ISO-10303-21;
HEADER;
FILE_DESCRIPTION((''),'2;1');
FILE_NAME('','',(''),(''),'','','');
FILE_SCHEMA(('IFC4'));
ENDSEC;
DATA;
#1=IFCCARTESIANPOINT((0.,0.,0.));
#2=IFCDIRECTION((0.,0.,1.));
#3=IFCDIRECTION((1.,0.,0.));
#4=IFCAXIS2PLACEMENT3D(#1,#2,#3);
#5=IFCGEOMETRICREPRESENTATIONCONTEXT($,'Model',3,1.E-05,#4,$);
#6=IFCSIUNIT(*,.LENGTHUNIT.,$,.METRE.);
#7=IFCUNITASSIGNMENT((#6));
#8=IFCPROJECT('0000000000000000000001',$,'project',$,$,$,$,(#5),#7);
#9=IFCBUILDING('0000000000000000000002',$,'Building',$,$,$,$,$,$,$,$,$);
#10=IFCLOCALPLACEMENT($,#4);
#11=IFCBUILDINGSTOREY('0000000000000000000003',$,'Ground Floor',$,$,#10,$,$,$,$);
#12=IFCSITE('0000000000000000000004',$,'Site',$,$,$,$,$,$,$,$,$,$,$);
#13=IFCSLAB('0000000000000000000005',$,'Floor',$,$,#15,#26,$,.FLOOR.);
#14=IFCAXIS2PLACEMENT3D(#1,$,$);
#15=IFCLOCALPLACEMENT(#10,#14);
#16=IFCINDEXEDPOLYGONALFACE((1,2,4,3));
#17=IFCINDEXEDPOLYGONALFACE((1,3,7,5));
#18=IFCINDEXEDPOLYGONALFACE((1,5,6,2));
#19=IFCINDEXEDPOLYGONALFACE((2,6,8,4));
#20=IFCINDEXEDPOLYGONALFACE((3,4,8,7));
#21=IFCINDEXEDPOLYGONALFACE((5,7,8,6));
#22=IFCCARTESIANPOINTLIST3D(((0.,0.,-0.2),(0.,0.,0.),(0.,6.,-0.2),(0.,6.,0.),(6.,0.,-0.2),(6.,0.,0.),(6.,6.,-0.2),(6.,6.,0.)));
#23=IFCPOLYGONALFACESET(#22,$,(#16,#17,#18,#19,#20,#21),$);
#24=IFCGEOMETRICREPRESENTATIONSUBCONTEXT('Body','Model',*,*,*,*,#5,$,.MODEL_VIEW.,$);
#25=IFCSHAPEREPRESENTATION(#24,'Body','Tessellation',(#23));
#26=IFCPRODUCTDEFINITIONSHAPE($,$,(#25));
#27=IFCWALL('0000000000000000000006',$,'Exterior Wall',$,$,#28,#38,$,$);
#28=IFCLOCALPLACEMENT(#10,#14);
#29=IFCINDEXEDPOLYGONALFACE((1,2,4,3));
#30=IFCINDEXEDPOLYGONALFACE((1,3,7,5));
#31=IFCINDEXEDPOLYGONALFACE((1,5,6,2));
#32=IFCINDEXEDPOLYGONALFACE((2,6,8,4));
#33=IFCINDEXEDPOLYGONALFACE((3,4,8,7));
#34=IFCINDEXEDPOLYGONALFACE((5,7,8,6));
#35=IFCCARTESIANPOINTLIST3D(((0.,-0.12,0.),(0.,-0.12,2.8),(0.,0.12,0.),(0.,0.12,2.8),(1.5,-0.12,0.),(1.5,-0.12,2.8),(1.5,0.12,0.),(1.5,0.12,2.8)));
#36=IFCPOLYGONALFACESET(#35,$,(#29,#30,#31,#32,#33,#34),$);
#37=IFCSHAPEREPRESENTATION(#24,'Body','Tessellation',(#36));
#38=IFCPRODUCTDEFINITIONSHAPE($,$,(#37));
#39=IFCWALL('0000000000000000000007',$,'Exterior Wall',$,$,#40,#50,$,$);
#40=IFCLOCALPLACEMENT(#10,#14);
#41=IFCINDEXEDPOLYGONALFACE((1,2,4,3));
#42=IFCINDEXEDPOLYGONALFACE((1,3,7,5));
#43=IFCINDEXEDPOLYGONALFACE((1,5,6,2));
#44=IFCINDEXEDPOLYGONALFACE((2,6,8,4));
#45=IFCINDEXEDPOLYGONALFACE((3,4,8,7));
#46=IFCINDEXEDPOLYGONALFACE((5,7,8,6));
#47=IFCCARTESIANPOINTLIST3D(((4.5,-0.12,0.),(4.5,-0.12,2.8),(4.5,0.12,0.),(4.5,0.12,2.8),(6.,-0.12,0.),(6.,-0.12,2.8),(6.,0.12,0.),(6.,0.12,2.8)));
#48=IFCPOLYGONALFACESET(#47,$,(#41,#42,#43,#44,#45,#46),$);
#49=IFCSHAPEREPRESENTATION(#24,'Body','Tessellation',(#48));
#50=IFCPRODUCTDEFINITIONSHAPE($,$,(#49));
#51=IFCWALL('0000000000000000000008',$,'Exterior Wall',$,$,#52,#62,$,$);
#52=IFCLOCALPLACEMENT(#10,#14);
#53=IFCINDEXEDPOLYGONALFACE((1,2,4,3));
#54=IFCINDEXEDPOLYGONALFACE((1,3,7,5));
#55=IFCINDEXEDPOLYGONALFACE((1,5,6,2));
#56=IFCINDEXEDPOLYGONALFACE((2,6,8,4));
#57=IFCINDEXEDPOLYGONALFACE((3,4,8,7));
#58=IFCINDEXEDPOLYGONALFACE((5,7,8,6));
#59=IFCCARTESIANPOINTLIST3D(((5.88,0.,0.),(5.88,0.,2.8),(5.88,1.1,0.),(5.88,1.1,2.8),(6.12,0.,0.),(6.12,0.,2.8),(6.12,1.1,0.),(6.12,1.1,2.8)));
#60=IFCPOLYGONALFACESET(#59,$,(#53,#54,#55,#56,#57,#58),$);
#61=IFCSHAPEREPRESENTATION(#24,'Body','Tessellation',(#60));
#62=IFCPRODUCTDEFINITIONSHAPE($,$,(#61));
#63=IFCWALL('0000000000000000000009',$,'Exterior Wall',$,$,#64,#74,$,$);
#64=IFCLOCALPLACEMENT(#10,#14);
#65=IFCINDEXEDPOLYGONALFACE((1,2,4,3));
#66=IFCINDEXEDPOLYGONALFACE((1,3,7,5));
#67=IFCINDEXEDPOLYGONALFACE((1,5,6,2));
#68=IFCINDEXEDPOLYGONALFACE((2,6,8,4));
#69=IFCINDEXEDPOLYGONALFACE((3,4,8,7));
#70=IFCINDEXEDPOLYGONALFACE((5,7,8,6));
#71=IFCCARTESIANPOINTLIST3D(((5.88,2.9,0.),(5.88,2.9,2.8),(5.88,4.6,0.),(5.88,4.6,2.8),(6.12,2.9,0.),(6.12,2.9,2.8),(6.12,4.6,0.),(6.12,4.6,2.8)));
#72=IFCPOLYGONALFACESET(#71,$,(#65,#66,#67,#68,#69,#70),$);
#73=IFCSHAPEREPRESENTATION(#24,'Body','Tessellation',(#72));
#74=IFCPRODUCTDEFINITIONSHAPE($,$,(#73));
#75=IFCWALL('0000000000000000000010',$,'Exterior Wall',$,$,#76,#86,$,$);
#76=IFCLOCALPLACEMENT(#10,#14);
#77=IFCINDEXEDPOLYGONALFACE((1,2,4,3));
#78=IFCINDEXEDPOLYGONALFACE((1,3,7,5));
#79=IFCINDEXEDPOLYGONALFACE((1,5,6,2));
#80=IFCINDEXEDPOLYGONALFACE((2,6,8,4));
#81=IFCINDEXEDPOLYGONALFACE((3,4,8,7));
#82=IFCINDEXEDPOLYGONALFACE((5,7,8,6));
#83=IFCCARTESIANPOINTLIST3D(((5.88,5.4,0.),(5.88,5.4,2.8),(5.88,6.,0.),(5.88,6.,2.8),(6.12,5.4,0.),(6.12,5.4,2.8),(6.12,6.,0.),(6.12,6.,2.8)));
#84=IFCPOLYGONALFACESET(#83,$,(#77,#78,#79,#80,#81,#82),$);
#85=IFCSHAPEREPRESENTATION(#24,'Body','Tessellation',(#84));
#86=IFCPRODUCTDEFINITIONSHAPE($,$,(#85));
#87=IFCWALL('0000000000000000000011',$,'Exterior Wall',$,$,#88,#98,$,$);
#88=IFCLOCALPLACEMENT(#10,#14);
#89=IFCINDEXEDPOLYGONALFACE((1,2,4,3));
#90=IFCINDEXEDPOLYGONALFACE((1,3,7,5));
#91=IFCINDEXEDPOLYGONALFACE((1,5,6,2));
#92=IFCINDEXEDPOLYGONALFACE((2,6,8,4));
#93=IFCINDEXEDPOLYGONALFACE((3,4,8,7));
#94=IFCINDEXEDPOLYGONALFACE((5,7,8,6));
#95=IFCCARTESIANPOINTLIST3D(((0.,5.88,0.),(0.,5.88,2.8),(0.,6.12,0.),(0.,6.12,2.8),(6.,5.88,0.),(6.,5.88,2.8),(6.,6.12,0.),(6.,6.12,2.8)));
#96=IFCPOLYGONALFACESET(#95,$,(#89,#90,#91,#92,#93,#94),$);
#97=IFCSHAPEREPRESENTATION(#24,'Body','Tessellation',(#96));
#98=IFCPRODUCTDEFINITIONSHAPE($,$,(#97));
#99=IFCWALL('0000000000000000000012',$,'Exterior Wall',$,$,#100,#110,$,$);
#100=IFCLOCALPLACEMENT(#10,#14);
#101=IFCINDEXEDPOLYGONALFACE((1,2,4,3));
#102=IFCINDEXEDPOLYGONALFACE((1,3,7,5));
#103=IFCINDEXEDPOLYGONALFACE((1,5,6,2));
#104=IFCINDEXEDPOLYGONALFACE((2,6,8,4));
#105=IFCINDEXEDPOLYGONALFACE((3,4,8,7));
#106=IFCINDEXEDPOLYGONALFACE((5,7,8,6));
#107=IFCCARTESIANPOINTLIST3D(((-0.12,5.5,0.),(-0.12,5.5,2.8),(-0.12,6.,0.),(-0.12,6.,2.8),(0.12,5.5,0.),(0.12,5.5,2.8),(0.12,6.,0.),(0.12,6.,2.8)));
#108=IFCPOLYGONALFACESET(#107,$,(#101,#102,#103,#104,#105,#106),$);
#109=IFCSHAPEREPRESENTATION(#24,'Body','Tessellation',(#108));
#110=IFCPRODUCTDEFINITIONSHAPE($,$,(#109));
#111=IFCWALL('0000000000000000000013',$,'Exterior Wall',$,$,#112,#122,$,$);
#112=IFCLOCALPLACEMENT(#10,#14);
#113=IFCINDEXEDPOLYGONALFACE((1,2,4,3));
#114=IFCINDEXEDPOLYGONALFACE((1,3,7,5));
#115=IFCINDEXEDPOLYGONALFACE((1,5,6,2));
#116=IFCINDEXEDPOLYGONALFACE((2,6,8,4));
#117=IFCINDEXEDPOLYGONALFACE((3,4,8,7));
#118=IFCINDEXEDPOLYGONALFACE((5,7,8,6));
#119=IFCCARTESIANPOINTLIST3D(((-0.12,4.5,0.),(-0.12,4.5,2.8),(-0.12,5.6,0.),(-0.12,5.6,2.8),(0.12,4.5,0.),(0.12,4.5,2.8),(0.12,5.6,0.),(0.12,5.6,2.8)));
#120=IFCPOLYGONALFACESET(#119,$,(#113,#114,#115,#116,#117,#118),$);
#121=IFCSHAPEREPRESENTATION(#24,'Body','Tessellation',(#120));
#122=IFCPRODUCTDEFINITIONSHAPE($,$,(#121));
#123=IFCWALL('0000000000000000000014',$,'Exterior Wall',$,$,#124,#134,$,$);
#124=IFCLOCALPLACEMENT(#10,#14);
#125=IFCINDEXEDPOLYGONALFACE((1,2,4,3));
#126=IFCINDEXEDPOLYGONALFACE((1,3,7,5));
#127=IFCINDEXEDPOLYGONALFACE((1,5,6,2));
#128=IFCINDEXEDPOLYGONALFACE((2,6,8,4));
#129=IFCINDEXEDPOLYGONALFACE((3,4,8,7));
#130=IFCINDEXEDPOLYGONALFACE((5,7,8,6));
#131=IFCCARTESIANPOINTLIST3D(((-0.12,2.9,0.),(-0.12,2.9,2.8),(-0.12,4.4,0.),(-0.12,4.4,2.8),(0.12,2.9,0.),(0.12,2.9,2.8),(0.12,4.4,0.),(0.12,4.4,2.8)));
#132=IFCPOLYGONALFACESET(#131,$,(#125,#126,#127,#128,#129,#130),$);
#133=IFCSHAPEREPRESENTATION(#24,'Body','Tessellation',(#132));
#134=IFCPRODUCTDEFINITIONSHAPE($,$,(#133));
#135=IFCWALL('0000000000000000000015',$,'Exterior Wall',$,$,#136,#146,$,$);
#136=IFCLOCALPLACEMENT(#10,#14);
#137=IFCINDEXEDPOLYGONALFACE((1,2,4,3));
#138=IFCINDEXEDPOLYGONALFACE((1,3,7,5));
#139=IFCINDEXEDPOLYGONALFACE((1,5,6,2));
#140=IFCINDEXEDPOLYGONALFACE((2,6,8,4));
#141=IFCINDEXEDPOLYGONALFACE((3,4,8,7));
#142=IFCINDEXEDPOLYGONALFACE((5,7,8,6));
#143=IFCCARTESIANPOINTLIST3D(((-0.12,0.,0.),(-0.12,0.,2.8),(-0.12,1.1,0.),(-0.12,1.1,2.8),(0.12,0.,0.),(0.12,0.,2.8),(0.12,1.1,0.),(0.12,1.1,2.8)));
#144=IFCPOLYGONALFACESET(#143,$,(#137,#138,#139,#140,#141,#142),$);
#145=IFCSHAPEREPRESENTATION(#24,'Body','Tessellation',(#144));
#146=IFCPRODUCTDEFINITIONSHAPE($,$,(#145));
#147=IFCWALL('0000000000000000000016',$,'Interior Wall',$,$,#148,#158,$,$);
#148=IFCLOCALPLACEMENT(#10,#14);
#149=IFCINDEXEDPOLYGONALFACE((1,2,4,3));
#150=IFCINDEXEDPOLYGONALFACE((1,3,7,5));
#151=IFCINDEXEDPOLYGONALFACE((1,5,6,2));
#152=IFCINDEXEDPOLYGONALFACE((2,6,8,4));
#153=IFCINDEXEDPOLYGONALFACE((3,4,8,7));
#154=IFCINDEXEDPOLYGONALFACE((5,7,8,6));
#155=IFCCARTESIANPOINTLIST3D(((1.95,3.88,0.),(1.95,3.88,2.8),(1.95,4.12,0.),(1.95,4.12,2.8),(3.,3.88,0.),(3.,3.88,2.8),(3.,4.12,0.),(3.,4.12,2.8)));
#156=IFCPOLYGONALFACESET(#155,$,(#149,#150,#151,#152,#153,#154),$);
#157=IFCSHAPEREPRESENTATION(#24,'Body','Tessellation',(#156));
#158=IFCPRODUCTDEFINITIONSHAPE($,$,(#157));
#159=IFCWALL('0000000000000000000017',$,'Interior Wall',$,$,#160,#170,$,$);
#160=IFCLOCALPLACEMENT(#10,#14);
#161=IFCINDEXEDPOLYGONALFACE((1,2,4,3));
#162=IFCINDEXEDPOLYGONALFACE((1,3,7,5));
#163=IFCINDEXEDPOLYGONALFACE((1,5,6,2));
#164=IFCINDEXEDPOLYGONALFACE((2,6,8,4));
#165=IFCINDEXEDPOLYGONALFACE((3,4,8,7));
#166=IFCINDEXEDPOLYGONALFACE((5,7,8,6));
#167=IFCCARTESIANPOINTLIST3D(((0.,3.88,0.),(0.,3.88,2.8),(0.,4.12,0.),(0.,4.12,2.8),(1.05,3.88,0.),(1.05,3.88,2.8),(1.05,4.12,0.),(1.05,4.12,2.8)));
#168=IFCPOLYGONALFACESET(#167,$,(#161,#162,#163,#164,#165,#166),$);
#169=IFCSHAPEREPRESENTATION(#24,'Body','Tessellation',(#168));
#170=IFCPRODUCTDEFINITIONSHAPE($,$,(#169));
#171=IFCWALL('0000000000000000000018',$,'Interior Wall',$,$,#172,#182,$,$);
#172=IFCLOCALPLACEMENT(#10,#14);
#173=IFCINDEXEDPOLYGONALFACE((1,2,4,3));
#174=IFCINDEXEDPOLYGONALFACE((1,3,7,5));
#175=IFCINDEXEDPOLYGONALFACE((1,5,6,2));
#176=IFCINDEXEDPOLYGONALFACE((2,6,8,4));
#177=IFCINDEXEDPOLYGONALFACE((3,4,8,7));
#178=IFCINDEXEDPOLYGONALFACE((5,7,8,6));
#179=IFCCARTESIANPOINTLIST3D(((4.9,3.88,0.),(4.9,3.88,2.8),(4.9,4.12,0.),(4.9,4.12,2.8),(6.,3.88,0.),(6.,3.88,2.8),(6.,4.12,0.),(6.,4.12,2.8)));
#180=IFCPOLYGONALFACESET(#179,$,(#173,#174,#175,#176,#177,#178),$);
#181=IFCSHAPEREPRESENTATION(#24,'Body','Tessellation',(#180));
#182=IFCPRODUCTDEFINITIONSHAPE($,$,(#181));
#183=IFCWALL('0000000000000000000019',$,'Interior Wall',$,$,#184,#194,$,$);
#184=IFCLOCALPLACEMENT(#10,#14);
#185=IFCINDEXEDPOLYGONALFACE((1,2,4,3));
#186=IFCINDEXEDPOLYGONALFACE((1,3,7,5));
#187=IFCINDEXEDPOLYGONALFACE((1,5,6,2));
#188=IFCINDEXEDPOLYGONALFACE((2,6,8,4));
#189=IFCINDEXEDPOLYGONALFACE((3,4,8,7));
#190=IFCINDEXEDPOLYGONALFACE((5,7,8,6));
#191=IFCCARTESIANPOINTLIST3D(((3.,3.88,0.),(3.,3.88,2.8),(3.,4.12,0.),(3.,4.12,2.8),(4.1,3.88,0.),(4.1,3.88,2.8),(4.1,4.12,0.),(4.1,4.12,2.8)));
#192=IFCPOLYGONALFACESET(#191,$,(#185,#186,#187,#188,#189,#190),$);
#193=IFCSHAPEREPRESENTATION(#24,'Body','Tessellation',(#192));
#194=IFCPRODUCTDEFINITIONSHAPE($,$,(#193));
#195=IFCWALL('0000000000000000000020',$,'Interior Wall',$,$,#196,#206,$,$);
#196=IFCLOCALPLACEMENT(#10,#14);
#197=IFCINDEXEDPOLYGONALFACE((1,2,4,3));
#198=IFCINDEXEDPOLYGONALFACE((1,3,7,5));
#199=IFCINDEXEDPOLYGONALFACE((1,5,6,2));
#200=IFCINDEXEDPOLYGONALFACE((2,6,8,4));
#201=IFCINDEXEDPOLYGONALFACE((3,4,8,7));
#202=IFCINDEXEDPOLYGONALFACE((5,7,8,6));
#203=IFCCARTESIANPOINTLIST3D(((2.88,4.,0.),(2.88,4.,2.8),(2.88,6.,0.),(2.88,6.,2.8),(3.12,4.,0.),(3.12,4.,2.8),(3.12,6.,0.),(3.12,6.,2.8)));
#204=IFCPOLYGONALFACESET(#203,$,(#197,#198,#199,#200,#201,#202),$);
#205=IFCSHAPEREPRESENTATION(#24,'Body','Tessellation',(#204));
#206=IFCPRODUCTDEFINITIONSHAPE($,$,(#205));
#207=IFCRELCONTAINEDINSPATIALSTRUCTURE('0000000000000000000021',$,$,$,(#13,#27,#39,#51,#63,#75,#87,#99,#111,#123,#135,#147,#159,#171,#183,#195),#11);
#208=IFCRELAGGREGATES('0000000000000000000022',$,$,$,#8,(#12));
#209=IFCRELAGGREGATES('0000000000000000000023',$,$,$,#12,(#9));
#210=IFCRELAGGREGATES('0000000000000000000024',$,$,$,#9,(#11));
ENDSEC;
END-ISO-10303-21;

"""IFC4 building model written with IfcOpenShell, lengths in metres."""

from ifc_helpers import new_model, si_unit, frame, origin_with_axes, place, context, subcontext, project, spatial, indexed_curve, outline, extrude, element, save


model = new_model("IFC4")

# Units and contexts
model_context = context("Model", 3, precision=1e-05, world=origin_with_axes())
body_context = subcontext(model_context, "Body", "Model", "MODEL_VIEW")
ifc_project = project(units=[si_unit("LENGTHUNIT", "METRE")], contexts=[model_context])

# Site, building, storey
site = spatial("IfcSite", under=ifc_project, Name="Site")
building = spatial("IfcBuilding", under=site, Name="Building")
storey_placement = place(None, origin_with_axes())
storey = spatial("IfcBuildingStorey", under=building, at=storey_placement, Name="Ground Floor")

# Slab
slab_placement = place(storey_placement, frame((0.0, 0.0, -0.2), z_axis=(0.0, 0.0, 1.0), x_axis=(1.0, 0.0, 0.0)))
element("IfcSlab", 1, at=slab_placement, inside=storey, Name="Floor", PredefinedType="FLOOR", context=body_context, shape_type="SweptSolid", body=[
    extrude(outline(indexed_curve([(0.0, 0.0), (6.0, 0.0), (6.0, 6.0), (0.0, 6.0)])), None, (0.0, 0.0, 1.0), 0.2),
])

# Walls
for number, where, z_axis, x_axis, name in (
    (2, (0.0, 0.0, 0.0), (0.0, 0.0, 1.0), (1.0, 0.0, 0.0), "Exterior Wall"),
    (3, (4.5, 0.0, 0.0), (0.0, 0.0, 1.0), (1.0, 0.0, 0.0), "Exterior Wall"),
):
    element("IfcWall", number, at=place(storey_placement, frame(where, z_axis=z_axis, x_axis=x_axis)), inside=storey, Name=name, context=body_context, shape_type="SweptSolid", body=[
        extrude(outline(indexed_curve([(0.0, 0.0), (0.0, 0.24), (1.5, 0.24), (1.5, 0.0), (0.0, 0.0)], self_intersect=False)), frame((0.0, -0.12, 0.0), z_axis=(0.0, 0.0, 1.0), x_axis=(1.0, 0.0, 0.0)), (0.0, 0.0, 1.0), 2.8),
    ])
wall_1_placement = place(storey_placement, frame((6.0, 0.0, 0.0), z_axis=(0.0, 0.0, 1.0), x_axis=(0.0, 1.0, 0.0)))
element("IfcWall", 4, at=wall_1_placement, inside=storey, Name="Exterior Wall", context=body_context, shape_type="SweptSolid", body=[
    extrude(outline(indexed_curve([(0.0, 0.0), (0.0, 0.24), (1.1, 0.24), (1.1, 0.0), (0.0, 0.0)], self_intersect=False)), frame((0.0, -0.12, 0.0), z_axis=(0.0, 0.0, 1.0), x_axis=(1.0, 0.0, 0.0)), (0.0, 0.0, 1.0), 2.8),
])
wall_2_placement = place(storey_placement, frame((6.0, 2.9, 0.0), z_axis=(0.0, 0.0, 1.0), x_axis=(0.0, 1.0, 0.0)))
element("IfcWall", 5, at=wall_2_placement, inside=storey, Name="Exterior Wall", context=body_context, shape_type="SweptSolid", body=[
    extrude(outline(indexed_curve([(0.0, 0.0), (0.0, 0.24), (1.7, 0.24), (1.7, 0.0), (0.0, 0.0)], self_intersect=False)), frame((0.0, -0.12, 0.0), z_axis=(0.0, 0.0, 1.0), x_axis=(1.0, 0.0, 0.0)), (0.0, 0.0, 1.0), 2.8),
])
wall_3_placement = place(storey_placement, frame((6.0, 5.4, 0.0), z_axis=(0.0, 0.0, 1.0), x_axis=(0.0, 1.0, 0.0)))
element("IfcWall", 6, at=wall_3_placement, inside=storey, Name="Exterior Wall", context=body_context, shape_type="SweptSolid", body=[
    extrude(outline(indexed_curve([(0.0, 0.0), (0.0, 0.24), (0.6, 0.24), (0.6, 0.0), (0.0, 0.0)], self_intersect=False)), frame((0.0, -0.12, 0.0), z_axis=(0.0, 0.0, 1.0), x_axis=(1.0, 0.0, 0.0)), (0.0, 0.0, 1.0), 2.8),
])
wall_4_placement = place(storey_placement, frame((6.0, 6.0, 0.0), z_axis=(0.0, 0.0, 1.0), x_axis=(-1.0, 0.0, 0.0)))
element("IfcWall", 7, at=wall_4_placement, inside=storey, Name="Exterior Wall", context=body_context, shape_type="SweptSolid", body=[
    extrude(outline(indexed_curve([(0.0, 0.0), (0.0, 0.24), (6.0, 0.24), (6.0, 0.0), (0.0, 0.0)], self_intersect=False)), frame((0.0, -0.12, 0.0), z_axis=(0.0, 0.0, 1.0), x_axis=(1.0, 0.0, 0.0)), (0.0, 0.0, 1.0), 2.8),
])
wall_5_placement = place(storey_placement, frame((0.0, 6.0, 0.0), z_axis=(0.0, 0.0, 1.0), x_axis=(0.0, -1.0, 0.0)))
element("IfcWall", 8, at=wall_5_placement, inside=storey, Name="Exterior Wall", context=body_context, shape_type="SweptSolid", body=[
    extrude(outline(indexed_curve([(0.0, 0.0), (0.0, 0.24), (0.5, 0.24), (0.5, 0.0), (0.0, 0.0)], self_intersect=False)), frame((0.0, -0.12, 0.0), z_axis=(0.0, 0.0, 1.0), x_axis=(1.0, 0.0, 0.0)), (0.0, 0.0, 1.0), 2.8),
])
wall_6_placement = place(storey_placement, frame((0.0, 4.5, 0.0), z_axis=(0.0, 0.0, 1.0), x_axis=(0.0, 1.0, 0.0)))
element("IfcWall", 9, at=wall_6_placement, inside=storey, Name="Exterior Wall", context=body_context, shape_type="SweptSolid", body=[
    extrude(outline(indexed_curve([(0.0, 0.0), (0.0, 0.24), (1.1, 0.24), (1.1, 0.0), (0.0, 0.0)], self_intersect=False)), frame((0.0, -0.12, 0.0), z_axis=(0.0, 0.0, 1.0), x_axis=(1.0, 0.0, 0.0)), (0.0, 0.0, 1.0), 2.8),
])
wall_7_placement = place(storey_placement, frame((0.0, 4.4, 0.0), z_axis=(0.0, 0.0, 1.0), x_axis=(0.0, -1.0, 0.0)))
element("IfcWall", 10, at=wall_7_placement, inside=storey, Name="Exterior Wall", context=body_context, shape_type="SweptSolid", body=[
    extrude(outline(indexed_curve([(0.0, 0.0), (0.0, 0.24), (1.5, 0.24), (1.5, 0.0), (0.0, 0.0)], self_intersect=False)), frame((0.0, -0.12, 0.0), z_axis=(0.0, 0.0, 1.0), x_axis=(1.0, 0.0, 0.0)), (0.0, 0.0, 1.0), 2.8),
])
wall_8_placement = place(storey_placement, frame((0.0, 1.1, 0.0), z_axis=(0.0, 0.0, 1.0), x_axis=(0.0, -1.0, 0.0)))
element("IfcWall", 11, at=wall_8_placement, inside=storey, Name="Exterior Wall", context=body_context, shape_type="SweptSolid", body=[
    extrude(outline(indexed_curve([(0.0, 0.0), (0.0, 0.24), (1.1, 0.24), (1.1, 0.0), (0.0, 0.0)], self_intersect=False)), frame((0.0, -0.12, 0.0), z_axis=(0.0, 0.0, 1.0), x_axis=(1.0, 0.0, 0.0)), (0.0, 0.0, 1.0), 2.8),
])
for number, where, z_axis, x_axis, name in (
    (12, (3.0, 4.0, 0.0), (0.0, 0.0, 1.0), (-1.0, 0.0, 0.0), "Interior Wall"),
    (13, (1.05, 4.0, 0.0), (0.0, 0.0, 1.0), (-1.0, 0.0, 0.0), "Interior Wall"),
):
    element("IfcWall", number, at=place(storey_placement, frame(where, z_axis=z_axis, x_axis=x_axis)), inside=storey, Name=name, context=body_context, shape_type="SweptSolid", body=[
        extrude(outline(indexed_curve([(0.0, 0.0), (0.0, 0.24), (1.05, 0.24), (1.05, 0.0), (0.0, 0.0)], self_intersect=False)), frame((0.0, -0.12, 0.0), z_axis=(0.0, 0.0, 1.0), x_axis=(1.0, 0.0, 0.0)), (0.0, 0.0, 1.0), 2.8),
    ])
for number, where, z_axis, x_axis, name in (
    (14, (6.0, 4.0, 0.0), (0.0, 0.0, 1.0), (-1.0, 0.0, 0.0), "Interior Wall"),
    (15, (4.1, 4.0, 0.0), (0.0, 0.0, 1.0), (-1.0, 0.0, 0.0), "Interior Wall"),
):
    element("IfcWall", number, at=place(storey_placement, frame(where, z_axis=z_axis, x_axis=x_axis)), inside=storey, Name=name, context=body_context, shape_type="SweptSolid", body=[
        extrude(outline(indexed_curve([(0.0, 0.0), (0.0, 0.24), (1.1, 0.24), (1.1, 0.0), (0.0, 0.0)], self_intersect=False)), frame((0.0, -0.12, 0.0), z_axis=(0.0, 0.0, 1.0), x_axis=(1.0, 0.0, 0.0)), (0.0, 0.0, 1.0), 2.8),
    ])
wall_9_placement = place(storey_placement, frame((3.0, 4.0, 0.0), z_axis=(0.0, 0.0, 1.0), x_axis=(0.0, 1.0, 0.0)))
element("IfcWall", 16, at=wall_9_placement, inside=storey, Name="Interior Wall", context=body_context, shape_type="SweptSolid", body=[
    extrude(outline(indexed_curve([(0.0, 0.0), (0.0, 0.24), (2.0, 0.24), (2.0, 0.0), (0.0, 0.0)], self_intersect=False)), frame((0.0, -0.12, 0.0), z_axis=(0.0, 0.0, 1.0), x_axis=(1.0, 0.0, 0.0)), (0.0, 0.0, 1.0), 2.8),
])

save(model, "model.ifc")
